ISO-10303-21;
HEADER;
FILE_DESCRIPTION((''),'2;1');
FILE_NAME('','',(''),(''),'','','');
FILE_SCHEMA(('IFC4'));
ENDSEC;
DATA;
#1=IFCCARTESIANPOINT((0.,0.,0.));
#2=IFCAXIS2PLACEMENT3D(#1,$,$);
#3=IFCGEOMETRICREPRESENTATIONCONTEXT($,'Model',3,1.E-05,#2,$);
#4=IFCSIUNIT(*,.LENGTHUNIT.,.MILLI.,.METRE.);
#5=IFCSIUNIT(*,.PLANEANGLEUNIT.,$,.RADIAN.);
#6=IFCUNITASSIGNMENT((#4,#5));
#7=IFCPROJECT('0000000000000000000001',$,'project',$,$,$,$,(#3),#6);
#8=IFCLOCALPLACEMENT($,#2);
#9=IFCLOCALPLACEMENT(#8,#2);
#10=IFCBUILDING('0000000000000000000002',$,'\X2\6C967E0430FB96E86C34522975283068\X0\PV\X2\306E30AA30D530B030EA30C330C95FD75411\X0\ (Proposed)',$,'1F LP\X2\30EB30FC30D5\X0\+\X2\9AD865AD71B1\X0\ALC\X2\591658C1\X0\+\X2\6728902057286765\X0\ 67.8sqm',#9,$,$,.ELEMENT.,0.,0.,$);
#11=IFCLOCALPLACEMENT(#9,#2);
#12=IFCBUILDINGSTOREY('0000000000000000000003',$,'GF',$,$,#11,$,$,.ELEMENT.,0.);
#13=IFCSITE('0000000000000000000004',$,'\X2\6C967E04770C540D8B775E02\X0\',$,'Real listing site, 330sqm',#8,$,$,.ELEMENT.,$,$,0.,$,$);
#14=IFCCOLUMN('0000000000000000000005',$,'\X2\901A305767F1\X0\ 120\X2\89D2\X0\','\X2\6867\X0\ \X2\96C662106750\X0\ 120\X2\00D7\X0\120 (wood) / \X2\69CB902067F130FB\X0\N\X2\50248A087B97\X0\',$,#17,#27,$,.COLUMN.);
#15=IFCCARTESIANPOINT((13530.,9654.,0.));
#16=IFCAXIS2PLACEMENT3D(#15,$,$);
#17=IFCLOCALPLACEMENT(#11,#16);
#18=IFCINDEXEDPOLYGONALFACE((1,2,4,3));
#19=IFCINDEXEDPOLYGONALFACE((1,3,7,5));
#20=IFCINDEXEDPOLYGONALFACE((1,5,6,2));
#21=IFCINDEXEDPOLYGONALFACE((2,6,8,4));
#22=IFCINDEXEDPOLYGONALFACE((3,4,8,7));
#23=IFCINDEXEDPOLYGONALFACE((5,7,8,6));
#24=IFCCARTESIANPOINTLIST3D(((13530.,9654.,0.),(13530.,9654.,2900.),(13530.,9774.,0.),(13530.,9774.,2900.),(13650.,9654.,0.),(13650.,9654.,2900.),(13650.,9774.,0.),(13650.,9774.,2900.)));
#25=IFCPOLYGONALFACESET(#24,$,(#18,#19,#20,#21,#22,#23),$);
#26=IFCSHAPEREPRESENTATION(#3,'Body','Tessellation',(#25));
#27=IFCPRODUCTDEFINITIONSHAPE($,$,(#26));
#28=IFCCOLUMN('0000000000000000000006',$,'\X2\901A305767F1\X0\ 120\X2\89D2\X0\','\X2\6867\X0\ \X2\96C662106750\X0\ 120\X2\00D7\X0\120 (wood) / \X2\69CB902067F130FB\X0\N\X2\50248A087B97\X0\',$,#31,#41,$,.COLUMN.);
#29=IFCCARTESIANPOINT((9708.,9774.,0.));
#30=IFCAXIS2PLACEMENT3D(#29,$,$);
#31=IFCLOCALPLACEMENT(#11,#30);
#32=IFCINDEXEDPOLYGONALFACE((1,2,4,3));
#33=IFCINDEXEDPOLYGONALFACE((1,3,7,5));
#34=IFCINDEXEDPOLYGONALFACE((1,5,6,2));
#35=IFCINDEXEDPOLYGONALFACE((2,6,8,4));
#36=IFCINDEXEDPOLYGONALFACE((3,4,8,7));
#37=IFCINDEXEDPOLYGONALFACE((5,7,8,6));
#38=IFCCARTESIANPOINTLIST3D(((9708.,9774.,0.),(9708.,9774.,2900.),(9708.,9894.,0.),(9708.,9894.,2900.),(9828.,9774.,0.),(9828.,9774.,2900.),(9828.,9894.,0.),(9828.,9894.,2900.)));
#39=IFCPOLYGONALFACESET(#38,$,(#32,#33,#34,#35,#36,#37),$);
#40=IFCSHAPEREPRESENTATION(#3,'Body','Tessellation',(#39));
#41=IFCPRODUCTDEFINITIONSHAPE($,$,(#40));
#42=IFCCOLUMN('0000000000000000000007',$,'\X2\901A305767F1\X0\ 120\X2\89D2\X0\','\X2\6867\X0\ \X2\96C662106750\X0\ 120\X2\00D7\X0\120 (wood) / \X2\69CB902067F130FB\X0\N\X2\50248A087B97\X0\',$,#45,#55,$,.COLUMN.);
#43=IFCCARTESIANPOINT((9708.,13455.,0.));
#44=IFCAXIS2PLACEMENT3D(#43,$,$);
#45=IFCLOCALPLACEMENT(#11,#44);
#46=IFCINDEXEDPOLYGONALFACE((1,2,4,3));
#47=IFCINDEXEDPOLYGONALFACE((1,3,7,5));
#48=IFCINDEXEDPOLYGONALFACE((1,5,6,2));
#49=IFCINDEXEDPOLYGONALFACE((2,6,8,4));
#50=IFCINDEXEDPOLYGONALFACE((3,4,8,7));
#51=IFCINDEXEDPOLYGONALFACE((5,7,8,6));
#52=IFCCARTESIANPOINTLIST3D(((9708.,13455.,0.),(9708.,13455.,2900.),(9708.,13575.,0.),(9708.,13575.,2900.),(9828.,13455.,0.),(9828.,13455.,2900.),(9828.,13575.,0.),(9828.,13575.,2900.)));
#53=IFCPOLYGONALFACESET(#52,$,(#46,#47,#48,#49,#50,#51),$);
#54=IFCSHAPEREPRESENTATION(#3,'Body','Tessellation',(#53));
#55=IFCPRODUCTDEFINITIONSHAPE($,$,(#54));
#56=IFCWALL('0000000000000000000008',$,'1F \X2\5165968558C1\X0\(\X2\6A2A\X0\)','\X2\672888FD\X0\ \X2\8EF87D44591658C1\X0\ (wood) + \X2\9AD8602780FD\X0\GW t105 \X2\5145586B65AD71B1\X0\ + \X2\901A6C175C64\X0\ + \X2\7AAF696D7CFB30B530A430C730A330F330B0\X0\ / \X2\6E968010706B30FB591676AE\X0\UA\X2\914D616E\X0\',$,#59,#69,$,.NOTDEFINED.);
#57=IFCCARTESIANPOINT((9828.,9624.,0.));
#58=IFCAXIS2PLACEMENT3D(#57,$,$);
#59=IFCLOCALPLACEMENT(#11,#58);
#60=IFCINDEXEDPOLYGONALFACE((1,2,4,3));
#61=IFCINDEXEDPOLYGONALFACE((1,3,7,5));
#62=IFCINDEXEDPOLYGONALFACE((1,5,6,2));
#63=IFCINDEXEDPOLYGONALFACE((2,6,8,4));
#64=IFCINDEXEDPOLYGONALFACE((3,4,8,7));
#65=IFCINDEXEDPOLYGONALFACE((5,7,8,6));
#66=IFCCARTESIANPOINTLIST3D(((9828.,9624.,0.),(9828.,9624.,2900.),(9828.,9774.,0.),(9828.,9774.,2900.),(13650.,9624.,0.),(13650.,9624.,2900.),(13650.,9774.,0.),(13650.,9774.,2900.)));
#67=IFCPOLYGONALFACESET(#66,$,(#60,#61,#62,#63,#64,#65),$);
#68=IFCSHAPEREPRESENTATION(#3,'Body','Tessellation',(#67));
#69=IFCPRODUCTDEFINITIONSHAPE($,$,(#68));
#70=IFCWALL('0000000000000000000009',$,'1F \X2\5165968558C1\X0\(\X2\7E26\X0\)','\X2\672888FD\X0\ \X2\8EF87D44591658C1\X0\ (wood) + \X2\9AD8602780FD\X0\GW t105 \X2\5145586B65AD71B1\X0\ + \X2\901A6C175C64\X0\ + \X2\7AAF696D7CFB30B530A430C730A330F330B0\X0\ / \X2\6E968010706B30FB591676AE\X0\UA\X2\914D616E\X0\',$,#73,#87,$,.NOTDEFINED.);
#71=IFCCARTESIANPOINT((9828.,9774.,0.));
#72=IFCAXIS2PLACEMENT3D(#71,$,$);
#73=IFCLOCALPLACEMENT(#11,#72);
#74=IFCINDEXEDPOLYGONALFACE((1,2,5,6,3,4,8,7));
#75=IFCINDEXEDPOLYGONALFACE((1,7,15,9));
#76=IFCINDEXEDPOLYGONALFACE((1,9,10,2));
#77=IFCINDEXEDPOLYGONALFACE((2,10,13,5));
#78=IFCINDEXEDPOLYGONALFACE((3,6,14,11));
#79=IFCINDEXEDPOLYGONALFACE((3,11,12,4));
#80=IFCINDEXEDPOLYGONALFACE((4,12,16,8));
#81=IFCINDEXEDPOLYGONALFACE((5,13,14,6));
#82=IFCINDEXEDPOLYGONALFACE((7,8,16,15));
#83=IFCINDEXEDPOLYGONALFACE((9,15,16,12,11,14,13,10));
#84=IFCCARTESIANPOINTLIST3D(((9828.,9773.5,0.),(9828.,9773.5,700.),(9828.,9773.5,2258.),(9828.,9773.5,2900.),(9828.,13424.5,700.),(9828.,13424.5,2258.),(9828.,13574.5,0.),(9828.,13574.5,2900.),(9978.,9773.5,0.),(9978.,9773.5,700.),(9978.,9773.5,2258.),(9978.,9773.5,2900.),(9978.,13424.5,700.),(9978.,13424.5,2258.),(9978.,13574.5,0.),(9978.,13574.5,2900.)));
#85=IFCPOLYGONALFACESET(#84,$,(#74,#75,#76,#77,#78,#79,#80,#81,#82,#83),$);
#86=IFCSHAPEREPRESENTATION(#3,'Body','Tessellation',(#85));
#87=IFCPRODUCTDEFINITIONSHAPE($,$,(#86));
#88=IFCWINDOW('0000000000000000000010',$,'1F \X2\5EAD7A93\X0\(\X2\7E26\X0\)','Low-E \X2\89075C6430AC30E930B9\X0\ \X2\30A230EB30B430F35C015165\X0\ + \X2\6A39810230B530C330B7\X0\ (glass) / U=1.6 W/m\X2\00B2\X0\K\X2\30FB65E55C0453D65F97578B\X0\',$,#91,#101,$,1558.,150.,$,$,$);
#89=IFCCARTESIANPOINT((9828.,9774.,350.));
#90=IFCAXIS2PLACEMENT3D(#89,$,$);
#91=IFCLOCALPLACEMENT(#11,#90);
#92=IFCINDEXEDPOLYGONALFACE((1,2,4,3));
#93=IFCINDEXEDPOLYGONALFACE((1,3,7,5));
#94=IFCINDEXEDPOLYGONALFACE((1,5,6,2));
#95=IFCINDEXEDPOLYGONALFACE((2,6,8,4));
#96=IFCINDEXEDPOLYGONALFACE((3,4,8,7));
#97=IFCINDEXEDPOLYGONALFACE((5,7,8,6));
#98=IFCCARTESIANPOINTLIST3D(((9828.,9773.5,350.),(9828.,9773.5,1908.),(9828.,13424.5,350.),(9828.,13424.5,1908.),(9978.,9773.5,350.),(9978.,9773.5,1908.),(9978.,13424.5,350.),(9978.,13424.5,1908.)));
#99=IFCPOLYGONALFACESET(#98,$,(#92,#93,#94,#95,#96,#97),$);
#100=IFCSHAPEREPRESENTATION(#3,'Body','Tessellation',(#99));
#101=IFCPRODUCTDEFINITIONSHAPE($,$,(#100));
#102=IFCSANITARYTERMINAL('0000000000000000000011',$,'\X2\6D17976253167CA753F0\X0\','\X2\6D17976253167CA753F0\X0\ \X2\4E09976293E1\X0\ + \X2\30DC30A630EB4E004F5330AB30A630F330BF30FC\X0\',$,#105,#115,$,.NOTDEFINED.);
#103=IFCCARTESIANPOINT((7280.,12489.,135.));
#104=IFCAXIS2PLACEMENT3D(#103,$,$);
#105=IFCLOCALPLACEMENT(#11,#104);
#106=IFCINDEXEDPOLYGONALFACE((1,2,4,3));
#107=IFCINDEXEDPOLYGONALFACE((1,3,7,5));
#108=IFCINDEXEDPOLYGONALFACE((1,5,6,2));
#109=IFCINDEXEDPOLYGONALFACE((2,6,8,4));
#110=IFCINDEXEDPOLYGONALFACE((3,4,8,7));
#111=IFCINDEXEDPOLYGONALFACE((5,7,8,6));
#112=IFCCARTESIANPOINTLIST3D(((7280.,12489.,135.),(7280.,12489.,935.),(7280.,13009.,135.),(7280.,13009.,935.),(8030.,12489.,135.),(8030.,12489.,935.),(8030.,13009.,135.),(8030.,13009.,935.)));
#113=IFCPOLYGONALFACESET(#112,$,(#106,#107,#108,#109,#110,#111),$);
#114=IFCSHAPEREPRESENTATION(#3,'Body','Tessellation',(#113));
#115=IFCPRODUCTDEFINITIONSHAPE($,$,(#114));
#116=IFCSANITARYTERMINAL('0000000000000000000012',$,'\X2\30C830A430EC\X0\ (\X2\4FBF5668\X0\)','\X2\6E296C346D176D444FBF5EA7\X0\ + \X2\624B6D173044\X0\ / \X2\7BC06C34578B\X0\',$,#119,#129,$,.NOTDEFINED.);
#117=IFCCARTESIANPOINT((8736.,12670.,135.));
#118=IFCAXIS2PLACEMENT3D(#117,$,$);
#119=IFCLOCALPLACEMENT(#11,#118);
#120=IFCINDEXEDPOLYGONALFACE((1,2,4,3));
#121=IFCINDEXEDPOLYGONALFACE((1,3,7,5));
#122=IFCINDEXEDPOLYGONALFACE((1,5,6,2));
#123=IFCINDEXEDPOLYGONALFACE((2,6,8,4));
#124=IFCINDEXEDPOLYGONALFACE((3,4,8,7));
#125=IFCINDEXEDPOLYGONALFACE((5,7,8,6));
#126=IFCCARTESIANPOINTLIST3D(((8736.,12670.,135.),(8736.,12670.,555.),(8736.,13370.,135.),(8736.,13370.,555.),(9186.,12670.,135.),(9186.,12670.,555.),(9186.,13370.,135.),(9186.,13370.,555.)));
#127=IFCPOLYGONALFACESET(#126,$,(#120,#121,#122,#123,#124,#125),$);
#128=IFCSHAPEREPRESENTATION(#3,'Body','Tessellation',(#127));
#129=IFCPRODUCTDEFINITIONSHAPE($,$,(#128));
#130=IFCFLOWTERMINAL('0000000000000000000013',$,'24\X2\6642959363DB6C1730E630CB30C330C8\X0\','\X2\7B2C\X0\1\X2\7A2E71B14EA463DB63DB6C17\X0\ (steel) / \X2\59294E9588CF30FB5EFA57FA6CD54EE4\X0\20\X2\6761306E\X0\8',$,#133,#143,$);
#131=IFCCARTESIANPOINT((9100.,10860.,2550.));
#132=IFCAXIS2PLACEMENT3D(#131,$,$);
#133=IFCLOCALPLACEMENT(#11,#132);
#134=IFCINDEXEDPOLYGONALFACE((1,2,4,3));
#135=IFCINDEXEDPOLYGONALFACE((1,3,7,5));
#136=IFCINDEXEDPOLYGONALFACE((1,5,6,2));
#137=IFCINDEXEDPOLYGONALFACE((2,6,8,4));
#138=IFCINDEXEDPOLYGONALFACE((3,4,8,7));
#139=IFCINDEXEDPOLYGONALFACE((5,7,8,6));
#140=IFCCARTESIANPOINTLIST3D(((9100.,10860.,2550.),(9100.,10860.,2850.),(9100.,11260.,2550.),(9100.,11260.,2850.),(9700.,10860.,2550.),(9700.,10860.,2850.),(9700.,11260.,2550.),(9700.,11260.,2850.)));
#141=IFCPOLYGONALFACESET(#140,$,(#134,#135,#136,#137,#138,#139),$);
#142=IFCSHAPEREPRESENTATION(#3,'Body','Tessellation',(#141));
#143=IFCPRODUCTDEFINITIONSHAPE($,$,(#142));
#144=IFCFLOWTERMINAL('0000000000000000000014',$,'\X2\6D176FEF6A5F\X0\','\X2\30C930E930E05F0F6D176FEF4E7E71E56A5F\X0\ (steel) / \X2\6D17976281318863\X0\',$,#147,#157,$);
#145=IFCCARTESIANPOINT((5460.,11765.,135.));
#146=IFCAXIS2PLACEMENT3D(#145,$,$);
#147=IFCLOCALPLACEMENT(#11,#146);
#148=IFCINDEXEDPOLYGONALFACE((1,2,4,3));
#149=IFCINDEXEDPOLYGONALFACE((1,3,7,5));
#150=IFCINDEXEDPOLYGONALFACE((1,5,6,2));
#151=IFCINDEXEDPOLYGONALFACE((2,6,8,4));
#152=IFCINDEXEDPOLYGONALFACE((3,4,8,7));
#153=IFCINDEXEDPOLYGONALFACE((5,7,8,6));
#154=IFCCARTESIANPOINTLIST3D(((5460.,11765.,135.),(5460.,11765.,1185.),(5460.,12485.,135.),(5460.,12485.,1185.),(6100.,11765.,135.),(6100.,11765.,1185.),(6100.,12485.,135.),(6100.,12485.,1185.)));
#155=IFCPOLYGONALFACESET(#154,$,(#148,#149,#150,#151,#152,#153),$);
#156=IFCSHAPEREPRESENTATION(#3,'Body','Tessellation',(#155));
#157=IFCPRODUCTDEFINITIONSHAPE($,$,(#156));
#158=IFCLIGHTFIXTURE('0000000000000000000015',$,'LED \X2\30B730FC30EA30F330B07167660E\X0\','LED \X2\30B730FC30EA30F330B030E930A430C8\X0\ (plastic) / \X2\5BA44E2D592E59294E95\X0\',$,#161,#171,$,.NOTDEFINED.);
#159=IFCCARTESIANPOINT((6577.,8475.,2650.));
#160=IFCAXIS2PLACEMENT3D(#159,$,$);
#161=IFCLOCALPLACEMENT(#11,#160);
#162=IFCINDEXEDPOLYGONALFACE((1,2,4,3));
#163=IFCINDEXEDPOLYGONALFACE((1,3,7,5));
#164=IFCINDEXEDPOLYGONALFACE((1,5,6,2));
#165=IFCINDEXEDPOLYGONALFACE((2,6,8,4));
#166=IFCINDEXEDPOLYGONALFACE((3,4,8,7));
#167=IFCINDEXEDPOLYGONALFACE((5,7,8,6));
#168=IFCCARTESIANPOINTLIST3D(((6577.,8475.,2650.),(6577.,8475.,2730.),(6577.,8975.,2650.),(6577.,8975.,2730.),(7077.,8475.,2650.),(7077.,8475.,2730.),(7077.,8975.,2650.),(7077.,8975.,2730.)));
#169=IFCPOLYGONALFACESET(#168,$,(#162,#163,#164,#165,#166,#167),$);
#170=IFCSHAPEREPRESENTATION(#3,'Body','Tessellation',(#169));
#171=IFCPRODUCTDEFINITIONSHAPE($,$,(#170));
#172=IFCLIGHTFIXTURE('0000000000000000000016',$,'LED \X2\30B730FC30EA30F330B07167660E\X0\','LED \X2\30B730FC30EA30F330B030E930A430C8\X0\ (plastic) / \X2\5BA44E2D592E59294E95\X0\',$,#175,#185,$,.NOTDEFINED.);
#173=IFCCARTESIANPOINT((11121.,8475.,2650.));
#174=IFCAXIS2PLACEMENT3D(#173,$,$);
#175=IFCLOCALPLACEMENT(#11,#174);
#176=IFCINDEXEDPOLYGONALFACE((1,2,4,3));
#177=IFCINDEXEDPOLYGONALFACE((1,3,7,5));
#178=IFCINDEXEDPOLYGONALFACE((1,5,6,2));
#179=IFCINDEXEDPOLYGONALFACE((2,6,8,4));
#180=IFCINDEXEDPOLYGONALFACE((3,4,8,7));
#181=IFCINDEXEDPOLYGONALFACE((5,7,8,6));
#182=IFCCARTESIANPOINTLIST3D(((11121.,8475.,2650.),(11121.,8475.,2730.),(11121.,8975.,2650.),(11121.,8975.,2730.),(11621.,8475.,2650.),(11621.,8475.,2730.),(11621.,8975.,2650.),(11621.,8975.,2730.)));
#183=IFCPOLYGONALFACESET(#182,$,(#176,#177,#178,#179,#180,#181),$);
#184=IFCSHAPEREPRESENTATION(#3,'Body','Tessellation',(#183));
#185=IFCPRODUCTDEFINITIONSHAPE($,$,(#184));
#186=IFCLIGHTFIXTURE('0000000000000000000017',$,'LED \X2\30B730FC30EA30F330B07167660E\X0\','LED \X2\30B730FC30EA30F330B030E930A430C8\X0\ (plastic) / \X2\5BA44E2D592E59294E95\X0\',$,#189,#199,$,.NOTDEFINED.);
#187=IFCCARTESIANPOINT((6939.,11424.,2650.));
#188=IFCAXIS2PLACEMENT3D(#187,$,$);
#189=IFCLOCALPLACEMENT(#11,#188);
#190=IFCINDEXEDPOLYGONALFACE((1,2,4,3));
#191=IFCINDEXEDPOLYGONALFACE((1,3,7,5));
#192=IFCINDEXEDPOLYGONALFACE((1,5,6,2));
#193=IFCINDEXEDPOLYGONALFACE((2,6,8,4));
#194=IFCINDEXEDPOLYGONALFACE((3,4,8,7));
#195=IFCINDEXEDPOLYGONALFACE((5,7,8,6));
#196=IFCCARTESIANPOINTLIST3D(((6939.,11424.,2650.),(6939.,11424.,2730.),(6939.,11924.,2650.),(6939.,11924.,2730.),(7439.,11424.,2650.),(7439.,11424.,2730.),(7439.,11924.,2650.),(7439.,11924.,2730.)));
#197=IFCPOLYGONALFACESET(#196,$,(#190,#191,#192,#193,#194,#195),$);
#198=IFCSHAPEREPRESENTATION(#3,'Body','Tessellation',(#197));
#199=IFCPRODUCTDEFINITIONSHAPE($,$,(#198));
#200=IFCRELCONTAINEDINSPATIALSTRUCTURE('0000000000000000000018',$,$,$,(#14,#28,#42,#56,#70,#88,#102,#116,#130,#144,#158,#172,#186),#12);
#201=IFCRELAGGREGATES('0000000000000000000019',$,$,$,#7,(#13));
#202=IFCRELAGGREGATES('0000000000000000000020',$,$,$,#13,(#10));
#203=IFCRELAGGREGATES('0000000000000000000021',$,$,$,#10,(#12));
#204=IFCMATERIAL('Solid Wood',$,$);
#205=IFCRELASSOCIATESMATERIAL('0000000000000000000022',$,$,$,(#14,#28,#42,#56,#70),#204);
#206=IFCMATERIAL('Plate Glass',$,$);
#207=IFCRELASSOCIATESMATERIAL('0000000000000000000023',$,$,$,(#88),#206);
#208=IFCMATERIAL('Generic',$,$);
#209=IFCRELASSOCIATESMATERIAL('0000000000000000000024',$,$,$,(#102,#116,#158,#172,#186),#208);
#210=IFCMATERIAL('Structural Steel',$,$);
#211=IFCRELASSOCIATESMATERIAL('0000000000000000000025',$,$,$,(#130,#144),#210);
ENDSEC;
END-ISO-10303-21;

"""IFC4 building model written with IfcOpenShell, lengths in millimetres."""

from ifc_helpers import new_model, si_unit, frame, frame_2d, origin, place, context, project, spatial, rectangle, extrude, material, element, fill, save


model = new_model("IFC4")

# Units and contexts
model_context = context("Model", 3, precision=1e-05, world=origin())
ifc_project = project(units=[si_unit("LENGTHUNIT", "METRE", prefix="MILLI"), si_unit("PLANEANGLEUNIT", "RADIAN")], contexts=[model_context])

# Site, building, storey
site_placement = place(None, origin())
site = spatial("IfcSite", under=ifc_project, at=site_placement, Name="沖縄県名護市", ObjectType="Real listing site, 330sqm", CompositionType="ELEMENT", RefElevation=0.0)
building_placement = place(site_placement, origin())
building = spatial("IfcBuilding", under=site, at=building_placement, Name="沖縄・雨水利用とPVのオフグリッド志向 (Proposed)", ObjectType="1F LPルーフ+高断熱ALC外壁+木造在来 67.8sqm", CompositionType="ELEMENT", ElevationOfRefHeight=0.0, ElevationOfTerrain=0.0)
storey_placement = place(building_placement, origin())
storey = spatial("IfcBuildingStorey", under=building, at=storey_placement, Name="GF", CompositionType="ELEMENT", Elevation=0.0)

# Columns
ifc_material_1 = material(Name="Solid Wood")
column_1_placement = place(storey_placement, frame((13530.0, 9654.0, 0.0)))
element("IfcColumn", 1, at=column_1_placement, inside=storey, material=ifc_material_1, Name="通し柱 120角", Description="桧 集成材 120×120 (wood) / 構造柱・N値計算", PredefinedType="COLUMN", context=model_context, shape_type="SweptSolid", body=[
    extrude(rectangle(XDim=120.0, YDim=120.0, at=frame_2d((60.0, 60.0))), frame((13530.0, 9654.0, 0.0)), (0.0, 0.0, 1.0), 2900.0),
])
column_2_placement = place(storey_placement, frame((9708.0, 9774.0, 0.0)))
element("IfcColumn", 2, at=column_2_placement, inside=storey, material=ifc_material_1, Name="通し柱 120角", Description="桧 集成材 120×120 (wood) / 構造柱・N値計算", PredefinedType="COLUMN", context=model_context, shape_type="SweptSolid", body=[
    extrude(rectangle(XDim=120.0, YDim=120.0, at=frame_2d((60.0, 60.0))), frame((9708.0, 9774.0, 0.0)), (0.0, 0.0, 1.0), 2900.0),
])
column_3_placement = place(storey_placement, frame((9708.0, 13455.0, 0.0)))
element("IfcColumn", 3, at=column_3_placement, inside=storey, material=ifc_material_1, Name="通し柱 120角", Description="桧 集成材 120×120 (wood) / 構造柱・N値計算", PredefinedType="COLUMN", context=model_context, shape_type="SweptSolid", body=[
    extrude(rectangle(XDim=120.0, YDim=120.0, at=frame_2d((60.0, 60.0))), frame((9708.0, 13455.0, 0.0)), (0.0, 0.0, 1.0), 2900.0),
])

# Wall
wall_1_placement = place(storey_placement, frame((9828.0, 9624.0, 0.0)))
element("IfcWall", 4, at=wall_1_placement, inside=storey, material=ifc_material_1, Name="1F 入隅壁(横)", Description="木製 軸組外壁 (wood) + 高性能GW t105 充填断熱 + 通気層 + 窯業系サイディング / 準耐火・外皮UA配慮", PredefinedType="NOTDEFINED", context=model_context, shape_type="SweptSolid", body=[
    extrude(rectangle(XDim=3822.0, YDim=150.0, at=frame_2d((1911.0, 75.0))), frame((9828.0, 9624.0, 0.0)), (0.0, 0.0, 1.0), 2900.0),
])

# Wall, opening, window
wall_2_placement = place(storey_placement, frame((9828.0, 9774.0, 0.0)))
wall_2 = element("IfcWall", 5, at=wall_2_placement, inside=storey, material=ifc_material_1, Name="1F 入隅壁(縦)", Description="木製 軸組外壁 (wood) + 高性能GW t105 充填断熱 + 通気層 + 窯業系サイディング / 準耐火・外皮UA配慮", PredefinedType="NOTDEFINED", context=model_context, shape_type="SweptSolid", body=[
    extrude(rectangle(XDim=150.0, YDim=3801.0, at=frame_2d((75.0, 1900.0))), frame((9828.0, 9774.0, 0.0)), (0.0, 0.0, 1.0), 2900.0),
])
opening_placement = place(storey_placement, frame((9828.0, 9774.0, 350.0)))
opening = element("IfcOpeningElement", 6, at=opening_placement, cuts=wall_2, PredefinedType="NOTDEFINED", context=model_context, shape_type="SweptSolid", body=[
    extrude(rectangle(XDim=150.0, YDim=3651.0, at=frame_2d((75.0, 1825.0))), frame((9828.0, 9774.0, 350.0)), (0.0, 0.0, 1.0), 1558.0),
])
ifc_material_2 = material(Name="Plate Glass")
window_placement = place(storey_placement, frame((9828.0, 9774.0, 350.0)))
window = element("IfcWindow", 7, at=window_placement, inside=storey, material=ifc_material_2, Name="1F 庭窓(縦)", Description="Low-E 複層ガラス アルゴン封入 + 樹脂サッシ (glass) / U=1.6 W/m²K・日射取得型", OverallHeight=1558.0, OverallWidth=150.0, context=model_context, shape_type="SweptSolid", body=[
    extrude(rectangle(XDim=150.0, YDim=3651.0, at=frame_2d((75.0, 1825.0))), frame((9828.0, 9774.0, 350.0)), (0.0, 0.0, 1.0), 1558.0),
])
fill(opening, window)

# Sanitary terminals
ifc_material_3 = material(Name="Generic")
sanitary_terminal_1_placement = place(storey_placement, frame((7280.0, 12489.0, 135.0)))
element("IfcSanitaryTerminal", 8, at=sanitary_terminal_1_placement, inside=storey, material=ifc_material_3, Name="洗面化粧台", Description="洗面化粧台 三面鏡 + ボウル一体カウンター", PredefinedType="NOTDEFINED", context=model_context, shape_type="SweptSolid", body=[
    extrude(rectangle(XDim=750.0, YDim=520.0, at=frame_2d((375.0, 260.0))), frame((7280.0, 12489.0, 135.0)), (0.0, 0.0, 1.0), 800.0),
])
sanitary_terminal_2_placement = place(storey_placement, frame((8736.0, 12670.0, 135.0)))
element("IfcSanitaryTerminal", 9, at=sanitary_terminal_2_placement, inside=storey, material=ifc_material_3, Name="トイレ (便器)", Description="温水洗浄便座 + 手洗い / 節水型", PredefinedType="NOTDEFINED", context=model_context, shape_type="SweptSolid", body=[
    extrude(rectangle(XDim=450.0, YDim=700.0, at=frame_2d((225.0, 350.0))), frame((8736.0, 12670.0, 135.0)), (0.0, 0.0, 1.0), 420.0),
])

# Flow terminals
ifc_material_4 = material(Name="Structural Steel")
flow_terminal_1_placement = place(storey_placement, frame((9100.0, 10860.0, 2550.0)))
element("IfcFlowTerminal", 10, at=flow_terminal_1_placement, inside=storey, material=ifc_material_4, Name="24時間換気ユニット", Description="第1種熱交換換気 (steel) / 天井裏・建基法令20条の8", context=model_context, shape_type="SweptSolid", body=[
    extrude(rectangle(XDim=600.0, YDim=400.0, at=frame_2d((300.0, 200.0))), frame((9100.0, 10860.0, 2550.0)), (0.0, 0.0, 1.0), 300.0),
])
flow_terminal_2_placement = place(storey_placement, frame((5460.0, 11765.0, 135.0)))
element("IfcFlowTerminal", 11, at=flow_terminal_2_placement, inside=storey, material=ifc_material_4, Name="洗濯機", Description="ドラム式洗濯乾燥機 (steel) / 洗面脱衣", context=model_context, shape_type="SweptSolid", body=[
    extrude(rectangle(XDim=640.0, YDim=720.0, at=frame_2d((320.0, 360.0))), frame((5460.0, 11765.0, 135.0)), (0.0, 0.0, 1.0), 1050.0),
])

# Light fixtures
light_fixture_1_placement = place(storey_placement, frame((6577.0, 8475.0, 2650.0)))
element("IfcLightFixture", 12, at=light_fixture_1_placement, inside=storey, material=ifc_material_3, Name="LED シーリング照明", Description="LED シーリングライト (plastic) / 室中央天井", PredefinedType="NOTDEFINED", context=model_context, shape_type="SweptSolid", body=[
    extrude(rectangle(XDim=500.0, YDim=500.0, at=frame_2d((250.0, 250.0))), frame((6577.0, 8475.0, 2650.0)), (0.0, 0.0, 1.0), 80.0),
])
light_fixture_2_placement = place(storey_placement, frame((11121.0, 8475.0, 2650.0)))
element("IfcLightFixture", 13, at=light_fixture_2_placement, inside=storey, material=ifc_material_3, Name="LED シーリング照明", Description="LED シーリングライト (plastic) / 室中央天井", PredefinedType="NOTDEFINED", context=model_context, shape_type="SweptSolid", body=[
    extrude(rectangle(XDim=500.0, YDim=500.0, at=frame_2d((250.0, 250.0))), frame((11121.0, 8475.0, 2650.0)), (0.0, 0.0, 1.0), 80.0),
])
light_fixture_3_placement = place(storey_placement, frame((6939.0, 11424.0, 2650.0)))
element("IfcLightFixture", 14, at=light_fixture_3_placement, inside=storey, material=ifc_material_3, Name="LED シーリング照明", Description="LED シーリングライト (plastic) / 室中央天井", PredefinedType="NOTDEFINED", context=model_context, shape_type="SweptSolid", body=[
    extrude(rectangle(XDim=500.0, YDim=500.0, at=frame_2d((250.0, 250.0))), frame((6939.0, 11424.0, 2650.0)), (0.0, 0.0, 1.0), 80.0),
])

save(model, "model.ifc")
